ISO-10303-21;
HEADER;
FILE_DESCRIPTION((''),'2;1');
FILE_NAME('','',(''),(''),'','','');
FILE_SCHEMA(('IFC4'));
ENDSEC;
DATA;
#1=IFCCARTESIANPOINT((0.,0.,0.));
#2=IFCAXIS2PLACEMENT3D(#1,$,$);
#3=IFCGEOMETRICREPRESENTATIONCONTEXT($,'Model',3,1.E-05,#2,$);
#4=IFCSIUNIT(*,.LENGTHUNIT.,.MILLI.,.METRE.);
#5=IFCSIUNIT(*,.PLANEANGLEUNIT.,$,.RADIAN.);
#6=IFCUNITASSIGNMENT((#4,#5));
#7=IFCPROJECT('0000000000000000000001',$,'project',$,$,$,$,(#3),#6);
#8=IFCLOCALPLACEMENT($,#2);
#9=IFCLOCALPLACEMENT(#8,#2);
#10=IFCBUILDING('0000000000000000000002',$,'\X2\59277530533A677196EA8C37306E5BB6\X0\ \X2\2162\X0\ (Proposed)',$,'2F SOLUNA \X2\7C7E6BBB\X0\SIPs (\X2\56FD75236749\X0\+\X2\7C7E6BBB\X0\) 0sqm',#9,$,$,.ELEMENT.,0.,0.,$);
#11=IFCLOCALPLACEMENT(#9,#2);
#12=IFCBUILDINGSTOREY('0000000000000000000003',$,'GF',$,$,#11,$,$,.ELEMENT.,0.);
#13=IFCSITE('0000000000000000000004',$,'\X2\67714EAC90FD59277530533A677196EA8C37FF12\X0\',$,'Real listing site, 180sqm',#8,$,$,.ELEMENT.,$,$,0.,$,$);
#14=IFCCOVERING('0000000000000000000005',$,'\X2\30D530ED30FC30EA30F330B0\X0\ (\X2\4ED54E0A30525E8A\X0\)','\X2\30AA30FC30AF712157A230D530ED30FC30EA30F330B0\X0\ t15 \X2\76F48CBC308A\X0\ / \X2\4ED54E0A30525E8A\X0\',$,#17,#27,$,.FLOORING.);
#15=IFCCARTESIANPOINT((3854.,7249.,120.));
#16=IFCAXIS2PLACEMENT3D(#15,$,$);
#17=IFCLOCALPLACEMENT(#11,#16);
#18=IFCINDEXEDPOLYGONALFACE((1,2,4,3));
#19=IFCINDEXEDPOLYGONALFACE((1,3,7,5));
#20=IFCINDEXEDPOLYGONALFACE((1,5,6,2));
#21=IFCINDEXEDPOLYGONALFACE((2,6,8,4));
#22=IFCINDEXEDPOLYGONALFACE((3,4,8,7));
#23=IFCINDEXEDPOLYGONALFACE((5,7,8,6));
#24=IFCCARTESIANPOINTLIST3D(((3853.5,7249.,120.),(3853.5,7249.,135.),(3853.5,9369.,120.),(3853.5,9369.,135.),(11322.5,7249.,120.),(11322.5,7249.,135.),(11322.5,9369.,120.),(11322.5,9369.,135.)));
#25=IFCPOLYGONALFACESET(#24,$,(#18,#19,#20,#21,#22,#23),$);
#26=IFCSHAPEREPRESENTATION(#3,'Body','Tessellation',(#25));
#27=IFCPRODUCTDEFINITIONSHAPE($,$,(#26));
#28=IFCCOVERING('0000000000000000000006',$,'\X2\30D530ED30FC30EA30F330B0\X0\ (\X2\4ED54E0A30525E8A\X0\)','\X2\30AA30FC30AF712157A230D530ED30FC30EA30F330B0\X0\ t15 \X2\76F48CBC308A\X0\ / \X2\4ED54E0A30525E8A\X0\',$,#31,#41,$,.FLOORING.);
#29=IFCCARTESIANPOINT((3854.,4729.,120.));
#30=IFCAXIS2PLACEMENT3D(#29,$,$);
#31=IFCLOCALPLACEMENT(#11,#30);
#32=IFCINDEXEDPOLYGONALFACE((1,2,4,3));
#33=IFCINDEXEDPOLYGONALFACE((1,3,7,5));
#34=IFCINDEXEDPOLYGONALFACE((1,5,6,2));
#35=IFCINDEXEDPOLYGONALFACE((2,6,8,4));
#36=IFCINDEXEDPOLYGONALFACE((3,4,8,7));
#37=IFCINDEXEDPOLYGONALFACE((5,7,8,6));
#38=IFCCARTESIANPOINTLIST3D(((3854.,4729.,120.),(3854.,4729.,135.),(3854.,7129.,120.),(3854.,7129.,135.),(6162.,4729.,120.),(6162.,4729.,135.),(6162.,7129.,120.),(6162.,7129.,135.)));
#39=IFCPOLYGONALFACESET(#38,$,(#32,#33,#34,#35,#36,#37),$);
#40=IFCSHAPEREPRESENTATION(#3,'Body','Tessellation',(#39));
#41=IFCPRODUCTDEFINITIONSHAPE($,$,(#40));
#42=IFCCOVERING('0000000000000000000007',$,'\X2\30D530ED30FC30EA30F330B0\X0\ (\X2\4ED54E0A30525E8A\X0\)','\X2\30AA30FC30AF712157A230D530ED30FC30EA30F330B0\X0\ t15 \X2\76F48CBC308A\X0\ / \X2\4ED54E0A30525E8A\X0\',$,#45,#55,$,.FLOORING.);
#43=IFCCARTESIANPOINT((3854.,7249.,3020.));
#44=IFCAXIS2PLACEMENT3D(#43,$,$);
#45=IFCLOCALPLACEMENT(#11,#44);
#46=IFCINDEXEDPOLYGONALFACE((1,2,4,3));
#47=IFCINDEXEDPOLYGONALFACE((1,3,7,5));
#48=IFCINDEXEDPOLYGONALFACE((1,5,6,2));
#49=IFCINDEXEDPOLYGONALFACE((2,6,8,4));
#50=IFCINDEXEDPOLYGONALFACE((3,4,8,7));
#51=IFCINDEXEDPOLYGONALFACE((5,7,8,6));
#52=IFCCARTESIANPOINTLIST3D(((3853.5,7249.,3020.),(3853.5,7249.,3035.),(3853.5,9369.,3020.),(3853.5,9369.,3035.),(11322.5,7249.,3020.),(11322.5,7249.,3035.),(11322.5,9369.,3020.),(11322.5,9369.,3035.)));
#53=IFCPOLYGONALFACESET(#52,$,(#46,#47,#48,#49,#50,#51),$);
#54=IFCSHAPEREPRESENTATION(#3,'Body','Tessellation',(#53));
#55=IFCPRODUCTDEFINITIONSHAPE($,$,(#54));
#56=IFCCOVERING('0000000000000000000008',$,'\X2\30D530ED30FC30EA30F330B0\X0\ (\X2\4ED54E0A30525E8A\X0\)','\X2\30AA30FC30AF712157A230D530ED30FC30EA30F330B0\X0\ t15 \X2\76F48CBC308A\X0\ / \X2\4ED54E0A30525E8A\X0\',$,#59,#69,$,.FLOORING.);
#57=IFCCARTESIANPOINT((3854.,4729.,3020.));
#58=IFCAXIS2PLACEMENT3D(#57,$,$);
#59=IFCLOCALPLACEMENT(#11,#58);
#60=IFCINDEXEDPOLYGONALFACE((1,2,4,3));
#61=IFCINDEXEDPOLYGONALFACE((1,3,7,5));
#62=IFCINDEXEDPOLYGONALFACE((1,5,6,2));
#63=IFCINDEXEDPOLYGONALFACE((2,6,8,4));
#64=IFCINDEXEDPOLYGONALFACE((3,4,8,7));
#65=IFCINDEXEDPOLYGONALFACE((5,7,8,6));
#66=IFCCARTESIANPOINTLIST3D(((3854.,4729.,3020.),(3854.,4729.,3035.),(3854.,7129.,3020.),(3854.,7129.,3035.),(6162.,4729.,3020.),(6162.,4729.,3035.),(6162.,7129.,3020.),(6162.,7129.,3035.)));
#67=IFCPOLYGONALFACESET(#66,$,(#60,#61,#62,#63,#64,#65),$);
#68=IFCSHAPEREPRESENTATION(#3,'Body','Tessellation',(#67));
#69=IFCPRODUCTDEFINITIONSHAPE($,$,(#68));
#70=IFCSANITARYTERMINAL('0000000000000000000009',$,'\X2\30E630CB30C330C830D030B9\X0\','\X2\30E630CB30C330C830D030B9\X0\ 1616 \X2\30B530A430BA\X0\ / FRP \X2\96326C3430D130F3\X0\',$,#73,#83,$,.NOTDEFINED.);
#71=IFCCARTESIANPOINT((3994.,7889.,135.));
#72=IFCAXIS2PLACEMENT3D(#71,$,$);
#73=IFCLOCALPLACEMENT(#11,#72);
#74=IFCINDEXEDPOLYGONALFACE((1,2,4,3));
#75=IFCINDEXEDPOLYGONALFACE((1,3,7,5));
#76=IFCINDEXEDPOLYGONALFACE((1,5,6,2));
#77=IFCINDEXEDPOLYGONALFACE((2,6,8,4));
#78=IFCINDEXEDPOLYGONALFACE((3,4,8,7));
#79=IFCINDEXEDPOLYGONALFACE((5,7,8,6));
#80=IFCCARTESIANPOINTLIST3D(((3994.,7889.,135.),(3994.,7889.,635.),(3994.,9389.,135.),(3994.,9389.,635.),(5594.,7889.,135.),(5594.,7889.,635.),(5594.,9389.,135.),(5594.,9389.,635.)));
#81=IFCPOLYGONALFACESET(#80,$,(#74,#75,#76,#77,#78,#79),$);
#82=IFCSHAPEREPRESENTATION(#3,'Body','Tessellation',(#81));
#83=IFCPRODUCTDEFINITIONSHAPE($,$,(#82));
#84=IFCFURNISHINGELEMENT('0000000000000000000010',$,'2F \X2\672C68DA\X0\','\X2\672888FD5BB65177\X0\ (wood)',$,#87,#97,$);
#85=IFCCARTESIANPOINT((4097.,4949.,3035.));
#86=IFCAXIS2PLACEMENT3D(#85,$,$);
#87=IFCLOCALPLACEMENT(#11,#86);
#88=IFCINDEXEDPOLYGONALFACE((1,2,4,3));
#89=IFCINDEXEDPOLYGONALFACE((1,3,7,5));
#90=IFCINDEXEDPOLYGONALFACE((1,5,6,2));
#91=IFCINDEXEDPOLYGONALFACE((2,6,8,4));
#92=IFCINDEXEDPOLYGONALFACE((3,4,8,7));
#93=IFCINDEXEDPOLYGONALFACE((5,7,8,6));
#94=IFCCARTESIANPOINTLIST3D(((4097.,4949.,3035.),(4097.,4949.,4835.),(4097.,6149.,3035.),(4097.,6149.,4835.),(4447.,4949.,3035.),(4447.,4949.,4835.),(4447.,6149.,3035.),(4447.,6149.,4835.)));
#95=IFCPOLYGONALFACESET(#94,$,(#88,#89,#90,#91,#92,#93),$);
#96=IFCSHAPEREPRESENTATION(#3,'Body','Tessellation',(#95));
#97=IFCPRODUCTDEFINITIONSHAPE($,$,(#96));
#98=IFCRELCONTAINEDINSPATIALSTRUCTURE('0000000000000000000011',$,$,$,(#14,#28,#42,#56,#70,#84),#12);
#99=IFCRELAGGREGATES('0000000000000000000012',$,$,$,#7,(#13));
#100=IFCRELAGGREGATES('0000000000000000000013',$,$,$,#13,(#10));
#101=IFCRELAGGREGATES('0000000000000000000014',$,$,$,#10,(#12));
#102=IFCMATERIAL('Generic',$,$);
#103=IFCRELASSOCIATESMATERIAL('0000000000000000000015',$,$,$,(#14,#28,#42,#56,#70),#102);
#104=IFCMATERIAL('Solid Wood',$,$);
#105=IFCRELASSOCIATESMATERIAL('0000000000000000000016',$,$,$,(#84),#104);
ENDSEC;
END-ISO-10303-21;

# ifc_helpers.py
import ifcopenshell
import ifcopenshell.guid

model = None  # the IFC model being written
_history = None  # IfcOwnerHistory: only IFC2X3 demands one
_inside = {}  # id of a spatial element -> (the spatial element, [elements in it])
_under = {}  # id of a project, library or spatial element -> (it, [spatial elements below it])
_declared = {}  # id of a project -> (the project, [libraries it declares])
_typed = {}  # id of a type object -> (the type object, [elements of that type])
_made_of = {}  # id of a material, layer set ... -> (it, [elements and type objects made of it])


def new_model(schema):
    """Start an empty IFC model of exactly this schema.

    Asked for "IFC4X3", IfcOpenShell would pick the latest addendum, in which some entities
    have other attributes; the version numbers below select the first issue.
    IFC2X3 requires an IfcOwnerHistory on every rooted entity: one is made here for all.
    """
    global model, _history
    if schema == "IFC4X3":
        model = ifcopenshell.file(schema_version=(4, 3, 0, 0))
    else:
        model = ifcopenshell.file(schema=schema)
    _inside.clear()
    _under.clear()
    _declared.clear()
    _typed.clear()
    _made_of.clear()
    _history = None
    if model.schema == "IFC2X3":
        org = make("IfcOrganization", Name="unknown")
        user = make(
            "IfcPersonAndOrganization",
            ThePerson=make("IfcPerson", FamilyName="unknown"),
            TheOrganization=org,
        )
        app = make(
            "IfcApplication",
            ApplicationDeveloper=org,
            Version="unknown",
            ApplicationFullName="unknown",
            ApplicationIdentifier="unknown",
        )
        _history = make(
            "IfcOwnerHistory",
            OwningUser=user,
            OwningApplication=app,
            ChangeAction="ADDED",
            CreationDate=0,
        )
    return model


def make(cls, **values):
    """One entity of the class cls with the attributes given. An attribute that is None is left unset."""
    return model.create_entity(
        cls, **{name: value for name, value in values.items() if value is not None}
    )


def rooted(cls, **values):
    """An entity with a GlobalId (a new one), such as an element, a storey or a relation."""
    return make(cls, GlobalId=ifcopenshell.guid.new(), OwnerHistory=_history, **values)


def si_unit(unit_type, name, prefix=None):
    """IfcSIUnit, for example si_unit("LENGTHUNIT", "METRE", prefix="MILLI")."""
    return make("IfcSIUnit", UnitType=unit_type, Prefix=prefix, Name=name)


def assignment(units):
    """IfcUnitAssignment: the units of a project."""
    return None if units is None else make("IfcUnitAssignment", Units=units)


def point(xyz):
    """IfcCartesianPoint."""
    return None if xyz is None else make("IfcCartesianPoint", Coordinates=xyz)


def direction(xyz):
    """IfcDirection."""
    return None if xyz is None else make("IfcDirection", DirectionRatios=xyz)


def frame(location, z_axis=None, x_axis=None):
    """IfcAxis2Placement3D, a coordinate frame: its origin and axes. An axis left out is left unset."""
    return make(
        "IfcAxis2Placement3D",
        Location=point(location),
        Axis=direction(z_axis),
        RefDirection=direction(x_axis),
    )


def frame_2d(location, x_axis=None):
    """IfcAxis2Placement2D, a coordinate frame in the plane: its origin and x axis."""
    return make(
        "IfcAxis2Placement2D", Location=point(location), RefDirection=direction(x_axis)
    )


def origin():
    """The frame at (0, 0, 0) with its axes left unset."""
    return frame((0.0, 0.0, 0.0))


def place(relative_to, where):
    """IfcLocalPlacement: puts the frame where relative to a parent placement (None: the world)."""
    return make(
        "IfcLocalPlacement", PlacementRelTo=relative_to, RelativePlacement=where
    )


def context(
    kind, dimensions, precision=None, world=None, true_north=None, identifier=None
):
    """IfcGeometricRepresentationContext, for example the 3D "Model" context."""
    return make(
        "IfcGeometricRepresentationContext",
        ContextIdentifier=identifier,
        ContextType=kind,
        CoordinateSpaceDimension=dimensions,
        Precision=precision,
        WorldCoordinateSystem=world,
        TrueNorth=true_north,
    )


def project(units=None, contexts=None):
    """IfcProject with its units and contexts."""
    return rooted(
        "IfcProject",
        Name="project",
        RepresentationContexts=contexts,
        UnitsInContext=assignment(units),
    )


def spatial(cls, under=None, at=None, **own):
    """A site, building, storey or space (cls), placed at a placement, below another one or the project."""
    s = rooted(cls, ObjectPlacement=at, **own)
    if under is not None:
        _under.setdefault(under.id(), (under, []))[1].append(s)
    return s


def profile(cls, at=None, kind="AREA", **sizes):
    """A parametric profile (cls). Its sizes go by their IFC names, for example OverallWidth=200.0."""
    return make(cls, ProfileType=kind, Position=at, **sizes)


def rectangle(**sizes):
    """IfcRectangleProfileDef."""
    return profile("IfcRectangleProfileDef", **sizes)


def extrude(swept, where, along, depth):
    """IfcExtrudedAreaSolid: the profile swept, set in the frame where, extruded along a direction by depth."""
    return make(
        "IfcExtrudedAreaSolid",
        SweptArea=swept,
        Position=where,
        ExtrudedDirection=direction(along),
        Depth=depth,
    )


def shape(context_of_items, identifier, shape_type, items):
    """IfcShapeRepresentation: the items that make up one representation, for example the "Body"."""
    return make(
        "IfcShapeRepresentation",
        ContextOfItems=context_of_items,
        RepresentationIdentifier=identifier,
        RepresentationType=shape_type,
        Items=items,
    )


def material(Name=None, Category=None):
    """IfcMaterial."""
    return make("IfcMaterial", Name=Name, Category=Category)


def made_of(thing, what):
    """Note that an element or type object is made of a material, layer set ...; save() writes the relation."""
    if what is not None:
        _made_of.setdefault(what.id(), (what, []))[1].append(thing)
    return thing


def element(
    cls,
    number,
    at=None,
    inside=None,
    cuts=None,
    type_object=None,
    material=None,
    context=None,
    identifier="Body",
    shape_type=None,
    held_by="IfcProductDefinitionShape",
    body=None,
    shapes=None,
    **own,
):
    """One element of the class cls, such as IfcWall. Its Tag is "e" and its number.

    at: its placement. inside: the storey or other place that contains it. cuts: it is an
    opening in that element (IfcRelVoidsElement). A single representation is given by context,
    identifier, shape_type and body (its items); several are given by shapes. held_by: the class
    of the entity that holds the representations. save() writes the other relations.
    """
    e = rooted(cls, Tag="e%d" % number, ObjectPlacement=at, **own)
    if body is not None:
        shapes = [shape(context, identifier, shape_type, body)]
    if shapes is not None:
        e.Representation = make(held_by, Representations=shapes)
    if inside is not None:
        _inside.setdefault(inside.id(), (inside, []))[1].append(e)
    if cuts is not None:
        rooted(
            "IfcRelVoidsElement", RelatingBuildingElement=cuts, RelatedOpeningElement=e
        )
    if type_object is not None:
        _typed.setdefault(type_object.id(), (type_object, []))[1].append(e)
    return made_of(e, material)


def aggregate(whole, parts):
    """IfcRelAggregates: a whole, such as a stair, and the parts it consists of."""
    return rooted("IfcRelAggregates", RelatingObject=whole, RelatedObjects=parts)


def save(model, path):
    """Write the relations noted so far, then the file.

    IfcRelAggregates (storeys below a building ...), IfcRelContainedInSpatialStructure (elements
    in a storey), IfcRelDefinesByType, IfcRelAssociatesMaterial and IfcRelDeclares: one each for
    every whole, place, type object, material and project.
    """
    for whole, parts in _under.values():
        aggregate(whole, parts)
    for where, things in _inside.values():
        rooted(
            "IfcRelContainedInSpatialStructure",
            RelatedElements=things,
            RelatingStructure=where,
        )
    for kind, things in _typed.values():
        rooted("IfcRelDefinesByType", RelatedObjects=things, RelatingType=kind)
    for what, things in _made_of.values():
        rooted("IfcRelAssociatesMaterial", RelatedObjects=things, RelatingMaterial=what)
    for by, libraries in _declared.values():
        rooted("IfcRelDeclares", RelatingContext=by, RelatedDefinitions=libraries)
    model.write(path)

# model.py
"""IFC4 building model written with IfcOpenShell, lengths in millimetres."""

from ifc_helpers import new_model, si_unit, frame, frame_2d, origin, place, context, project, spatial, rectangle, extrude, material, element, save


model = new_model("IFC4")

# Units and contexts
model_context = context("Model", 3, precision=1e-05, world=origin())
ifc_project = project(units=[si_unit("LENGTHUNIT", "METRE", prefix="MILLI"), si_unit("PLANEANGLEUNIT", "RADIAN")], contexts=[model_context])

# Site, building, storey
site_placement = place(None, origin())
site = spatial("IfcSite", under=ifc_project, at=site_placement, Name="東京都大田区東雪谷２", ObjectType="Real listing site, 180sqm", CompositionType="ELEMENT", RefElevation=0.0)
building_placement = place(site_placement, origin())
building = spatial("IfcBuilding", under=site, at=building_placement, Name="大田区東雪谷の家 Ⅲ (Proposed)", ObjectType="2F SOLUNA 籾殻SIPs (国産杉+籾殻) 0sqm", CompositionType="ELEMENT", ElevationOfRefHeight=0.0, ElevationOfTerrain=0.0)
storey_placement = place(building_placement, origin())
storey = spatial("IfcBuildingStorey", under=building, at=storey_placement, Name="GF", CompositionType="ELEMENT", Elevation=0.0)

# Shared definitions
ifc_material_1 = material(Name="Solid Wood")

# Coverings
ifc_material_2 = material(Name="Generic")
covering_1_placement = place(storey_placement, frame((3854.0, 7249.0, 120.0)))
element("IfcCovering", 1, at=covering_1_placement, inside=storey, material=ifc_material_2, Name="フローリング (仕上げ床)", Description="オーク無垢フローリング t15 直貼り / 仕上げ床", PredefinedType="FLOORING", context=model_context, shape_type="SweptSolid", body=[
    extrude(rectangle(XDim=7469.0, YDim=2120.0, at=frame_2d((3734.0, 1060.0))), frame((3854.0, 7249.0, 120.0)), (0.0, 0.0, 1.0), 15.0),
])
covering_2_placement = place(storey_placement, frame((3854.0, 4729.0, 120.0)))
element("IfcCovering", 2, at=covering_2_placement, inside=storey, material=ifc_material_2, Name="フローリング (仕上げ床)", Description="オーク無垢フローリング t15 直貼り / 仕上げ床", PredefinedType="FLOORING", context=model_context, shape_type="SweptSolid", body=[
    extrude(rectangle(XDim=2308.0, YDim=2400.0, at=frame_2d((1154.0, 1200.0))), frame((3854.0, 4729.0, 120.0)), (0.0, 0.0, 1.0), 15.0),
])
covering_3_placement = place(storey_placement, frame((3854.0, 7249.0, 3020.0)))
element("IfcCovering", 3, at=covering_3_placement, inside=storey, material=ifc_material_2, Name="フローリング (仕上げ床)", Description="オーク無垢フローリング t15 直貼り / 仕上げ床", PredefinedType="FLOORING", context=model_context, shape_type="SweptSolid", body=[
    extrude(rectangle(XDim=7469.0, YDim=2120.0, at=frame_2d((3734.0, 1060.0))), frame((3854.0, 7249.0, 3020.0)), (0.0, 0.0, 1.0), 15.0),
])
covering_4_placement = place(storey_placement, frame((3854.0, 4729.0, 3020.0)))
element("IfcCovering", 4, at=covering_4_placement, inside=storey, material=ifc_material_2, Name="フローリング (仕上げ床)", Description="オーク無垢フローリング t15 直貼り / 仕上げ床", PredefinedType="FLOORING", context=model_context, shape_type="SweptSolid", body=[
    extrude(rectangle(XDim=2308.0, YDim=2400.0, at=frame_2d((1154.0, 1200.0))), frame((3854.0, 4729.0, 3020.0)), (0.0, 0.0, 1.0), 15.0),
])

# Sanitary terminal
sanitary_terminal_placement = place(storey_placement, frame((3994.0, 7889.0, 135.0)))
element("IfcSanitaryTerminal", 5, at=sanitary_terminal_placement, inside=storey, material=ifc_material_2, Name="ユニットバス", Description="ユニットバス 1616 サイズ / FRP 防水パン", PredefinedType="NOTDEFINED", context=model_context, shape_type="SweptSolid", body=[
    extrude(rectangle(XDim=1600.0, YDim=1500.0, at=frame_2d((800.0, 750.0))), frame((3994.0, 7889.0, 135.0)), (0.0, 0.0, 1.0), 500.0),
])

# Furnishing element
furnishing_placement = place(storey_placement, frame((4097.0, 4949.0, 3035.0)))
element("IfcFurnishingElement", 6, at=furnishing_placement, inside=storey, material=ifc_material_1, Name="2F 本棚", Description="木製家具 (wood)", context=model_context, shape_type="SweptSolid", body=[
    extrude(rectangle(XDim=350.0, YDim=1200.0, at=frame_2d((175.0, 600.0))), frame((4097.0, 4949.0, 3035.0)), (0.0, 0.0, 1.0), 1800.0),
])

save(model, "model.ifc")
